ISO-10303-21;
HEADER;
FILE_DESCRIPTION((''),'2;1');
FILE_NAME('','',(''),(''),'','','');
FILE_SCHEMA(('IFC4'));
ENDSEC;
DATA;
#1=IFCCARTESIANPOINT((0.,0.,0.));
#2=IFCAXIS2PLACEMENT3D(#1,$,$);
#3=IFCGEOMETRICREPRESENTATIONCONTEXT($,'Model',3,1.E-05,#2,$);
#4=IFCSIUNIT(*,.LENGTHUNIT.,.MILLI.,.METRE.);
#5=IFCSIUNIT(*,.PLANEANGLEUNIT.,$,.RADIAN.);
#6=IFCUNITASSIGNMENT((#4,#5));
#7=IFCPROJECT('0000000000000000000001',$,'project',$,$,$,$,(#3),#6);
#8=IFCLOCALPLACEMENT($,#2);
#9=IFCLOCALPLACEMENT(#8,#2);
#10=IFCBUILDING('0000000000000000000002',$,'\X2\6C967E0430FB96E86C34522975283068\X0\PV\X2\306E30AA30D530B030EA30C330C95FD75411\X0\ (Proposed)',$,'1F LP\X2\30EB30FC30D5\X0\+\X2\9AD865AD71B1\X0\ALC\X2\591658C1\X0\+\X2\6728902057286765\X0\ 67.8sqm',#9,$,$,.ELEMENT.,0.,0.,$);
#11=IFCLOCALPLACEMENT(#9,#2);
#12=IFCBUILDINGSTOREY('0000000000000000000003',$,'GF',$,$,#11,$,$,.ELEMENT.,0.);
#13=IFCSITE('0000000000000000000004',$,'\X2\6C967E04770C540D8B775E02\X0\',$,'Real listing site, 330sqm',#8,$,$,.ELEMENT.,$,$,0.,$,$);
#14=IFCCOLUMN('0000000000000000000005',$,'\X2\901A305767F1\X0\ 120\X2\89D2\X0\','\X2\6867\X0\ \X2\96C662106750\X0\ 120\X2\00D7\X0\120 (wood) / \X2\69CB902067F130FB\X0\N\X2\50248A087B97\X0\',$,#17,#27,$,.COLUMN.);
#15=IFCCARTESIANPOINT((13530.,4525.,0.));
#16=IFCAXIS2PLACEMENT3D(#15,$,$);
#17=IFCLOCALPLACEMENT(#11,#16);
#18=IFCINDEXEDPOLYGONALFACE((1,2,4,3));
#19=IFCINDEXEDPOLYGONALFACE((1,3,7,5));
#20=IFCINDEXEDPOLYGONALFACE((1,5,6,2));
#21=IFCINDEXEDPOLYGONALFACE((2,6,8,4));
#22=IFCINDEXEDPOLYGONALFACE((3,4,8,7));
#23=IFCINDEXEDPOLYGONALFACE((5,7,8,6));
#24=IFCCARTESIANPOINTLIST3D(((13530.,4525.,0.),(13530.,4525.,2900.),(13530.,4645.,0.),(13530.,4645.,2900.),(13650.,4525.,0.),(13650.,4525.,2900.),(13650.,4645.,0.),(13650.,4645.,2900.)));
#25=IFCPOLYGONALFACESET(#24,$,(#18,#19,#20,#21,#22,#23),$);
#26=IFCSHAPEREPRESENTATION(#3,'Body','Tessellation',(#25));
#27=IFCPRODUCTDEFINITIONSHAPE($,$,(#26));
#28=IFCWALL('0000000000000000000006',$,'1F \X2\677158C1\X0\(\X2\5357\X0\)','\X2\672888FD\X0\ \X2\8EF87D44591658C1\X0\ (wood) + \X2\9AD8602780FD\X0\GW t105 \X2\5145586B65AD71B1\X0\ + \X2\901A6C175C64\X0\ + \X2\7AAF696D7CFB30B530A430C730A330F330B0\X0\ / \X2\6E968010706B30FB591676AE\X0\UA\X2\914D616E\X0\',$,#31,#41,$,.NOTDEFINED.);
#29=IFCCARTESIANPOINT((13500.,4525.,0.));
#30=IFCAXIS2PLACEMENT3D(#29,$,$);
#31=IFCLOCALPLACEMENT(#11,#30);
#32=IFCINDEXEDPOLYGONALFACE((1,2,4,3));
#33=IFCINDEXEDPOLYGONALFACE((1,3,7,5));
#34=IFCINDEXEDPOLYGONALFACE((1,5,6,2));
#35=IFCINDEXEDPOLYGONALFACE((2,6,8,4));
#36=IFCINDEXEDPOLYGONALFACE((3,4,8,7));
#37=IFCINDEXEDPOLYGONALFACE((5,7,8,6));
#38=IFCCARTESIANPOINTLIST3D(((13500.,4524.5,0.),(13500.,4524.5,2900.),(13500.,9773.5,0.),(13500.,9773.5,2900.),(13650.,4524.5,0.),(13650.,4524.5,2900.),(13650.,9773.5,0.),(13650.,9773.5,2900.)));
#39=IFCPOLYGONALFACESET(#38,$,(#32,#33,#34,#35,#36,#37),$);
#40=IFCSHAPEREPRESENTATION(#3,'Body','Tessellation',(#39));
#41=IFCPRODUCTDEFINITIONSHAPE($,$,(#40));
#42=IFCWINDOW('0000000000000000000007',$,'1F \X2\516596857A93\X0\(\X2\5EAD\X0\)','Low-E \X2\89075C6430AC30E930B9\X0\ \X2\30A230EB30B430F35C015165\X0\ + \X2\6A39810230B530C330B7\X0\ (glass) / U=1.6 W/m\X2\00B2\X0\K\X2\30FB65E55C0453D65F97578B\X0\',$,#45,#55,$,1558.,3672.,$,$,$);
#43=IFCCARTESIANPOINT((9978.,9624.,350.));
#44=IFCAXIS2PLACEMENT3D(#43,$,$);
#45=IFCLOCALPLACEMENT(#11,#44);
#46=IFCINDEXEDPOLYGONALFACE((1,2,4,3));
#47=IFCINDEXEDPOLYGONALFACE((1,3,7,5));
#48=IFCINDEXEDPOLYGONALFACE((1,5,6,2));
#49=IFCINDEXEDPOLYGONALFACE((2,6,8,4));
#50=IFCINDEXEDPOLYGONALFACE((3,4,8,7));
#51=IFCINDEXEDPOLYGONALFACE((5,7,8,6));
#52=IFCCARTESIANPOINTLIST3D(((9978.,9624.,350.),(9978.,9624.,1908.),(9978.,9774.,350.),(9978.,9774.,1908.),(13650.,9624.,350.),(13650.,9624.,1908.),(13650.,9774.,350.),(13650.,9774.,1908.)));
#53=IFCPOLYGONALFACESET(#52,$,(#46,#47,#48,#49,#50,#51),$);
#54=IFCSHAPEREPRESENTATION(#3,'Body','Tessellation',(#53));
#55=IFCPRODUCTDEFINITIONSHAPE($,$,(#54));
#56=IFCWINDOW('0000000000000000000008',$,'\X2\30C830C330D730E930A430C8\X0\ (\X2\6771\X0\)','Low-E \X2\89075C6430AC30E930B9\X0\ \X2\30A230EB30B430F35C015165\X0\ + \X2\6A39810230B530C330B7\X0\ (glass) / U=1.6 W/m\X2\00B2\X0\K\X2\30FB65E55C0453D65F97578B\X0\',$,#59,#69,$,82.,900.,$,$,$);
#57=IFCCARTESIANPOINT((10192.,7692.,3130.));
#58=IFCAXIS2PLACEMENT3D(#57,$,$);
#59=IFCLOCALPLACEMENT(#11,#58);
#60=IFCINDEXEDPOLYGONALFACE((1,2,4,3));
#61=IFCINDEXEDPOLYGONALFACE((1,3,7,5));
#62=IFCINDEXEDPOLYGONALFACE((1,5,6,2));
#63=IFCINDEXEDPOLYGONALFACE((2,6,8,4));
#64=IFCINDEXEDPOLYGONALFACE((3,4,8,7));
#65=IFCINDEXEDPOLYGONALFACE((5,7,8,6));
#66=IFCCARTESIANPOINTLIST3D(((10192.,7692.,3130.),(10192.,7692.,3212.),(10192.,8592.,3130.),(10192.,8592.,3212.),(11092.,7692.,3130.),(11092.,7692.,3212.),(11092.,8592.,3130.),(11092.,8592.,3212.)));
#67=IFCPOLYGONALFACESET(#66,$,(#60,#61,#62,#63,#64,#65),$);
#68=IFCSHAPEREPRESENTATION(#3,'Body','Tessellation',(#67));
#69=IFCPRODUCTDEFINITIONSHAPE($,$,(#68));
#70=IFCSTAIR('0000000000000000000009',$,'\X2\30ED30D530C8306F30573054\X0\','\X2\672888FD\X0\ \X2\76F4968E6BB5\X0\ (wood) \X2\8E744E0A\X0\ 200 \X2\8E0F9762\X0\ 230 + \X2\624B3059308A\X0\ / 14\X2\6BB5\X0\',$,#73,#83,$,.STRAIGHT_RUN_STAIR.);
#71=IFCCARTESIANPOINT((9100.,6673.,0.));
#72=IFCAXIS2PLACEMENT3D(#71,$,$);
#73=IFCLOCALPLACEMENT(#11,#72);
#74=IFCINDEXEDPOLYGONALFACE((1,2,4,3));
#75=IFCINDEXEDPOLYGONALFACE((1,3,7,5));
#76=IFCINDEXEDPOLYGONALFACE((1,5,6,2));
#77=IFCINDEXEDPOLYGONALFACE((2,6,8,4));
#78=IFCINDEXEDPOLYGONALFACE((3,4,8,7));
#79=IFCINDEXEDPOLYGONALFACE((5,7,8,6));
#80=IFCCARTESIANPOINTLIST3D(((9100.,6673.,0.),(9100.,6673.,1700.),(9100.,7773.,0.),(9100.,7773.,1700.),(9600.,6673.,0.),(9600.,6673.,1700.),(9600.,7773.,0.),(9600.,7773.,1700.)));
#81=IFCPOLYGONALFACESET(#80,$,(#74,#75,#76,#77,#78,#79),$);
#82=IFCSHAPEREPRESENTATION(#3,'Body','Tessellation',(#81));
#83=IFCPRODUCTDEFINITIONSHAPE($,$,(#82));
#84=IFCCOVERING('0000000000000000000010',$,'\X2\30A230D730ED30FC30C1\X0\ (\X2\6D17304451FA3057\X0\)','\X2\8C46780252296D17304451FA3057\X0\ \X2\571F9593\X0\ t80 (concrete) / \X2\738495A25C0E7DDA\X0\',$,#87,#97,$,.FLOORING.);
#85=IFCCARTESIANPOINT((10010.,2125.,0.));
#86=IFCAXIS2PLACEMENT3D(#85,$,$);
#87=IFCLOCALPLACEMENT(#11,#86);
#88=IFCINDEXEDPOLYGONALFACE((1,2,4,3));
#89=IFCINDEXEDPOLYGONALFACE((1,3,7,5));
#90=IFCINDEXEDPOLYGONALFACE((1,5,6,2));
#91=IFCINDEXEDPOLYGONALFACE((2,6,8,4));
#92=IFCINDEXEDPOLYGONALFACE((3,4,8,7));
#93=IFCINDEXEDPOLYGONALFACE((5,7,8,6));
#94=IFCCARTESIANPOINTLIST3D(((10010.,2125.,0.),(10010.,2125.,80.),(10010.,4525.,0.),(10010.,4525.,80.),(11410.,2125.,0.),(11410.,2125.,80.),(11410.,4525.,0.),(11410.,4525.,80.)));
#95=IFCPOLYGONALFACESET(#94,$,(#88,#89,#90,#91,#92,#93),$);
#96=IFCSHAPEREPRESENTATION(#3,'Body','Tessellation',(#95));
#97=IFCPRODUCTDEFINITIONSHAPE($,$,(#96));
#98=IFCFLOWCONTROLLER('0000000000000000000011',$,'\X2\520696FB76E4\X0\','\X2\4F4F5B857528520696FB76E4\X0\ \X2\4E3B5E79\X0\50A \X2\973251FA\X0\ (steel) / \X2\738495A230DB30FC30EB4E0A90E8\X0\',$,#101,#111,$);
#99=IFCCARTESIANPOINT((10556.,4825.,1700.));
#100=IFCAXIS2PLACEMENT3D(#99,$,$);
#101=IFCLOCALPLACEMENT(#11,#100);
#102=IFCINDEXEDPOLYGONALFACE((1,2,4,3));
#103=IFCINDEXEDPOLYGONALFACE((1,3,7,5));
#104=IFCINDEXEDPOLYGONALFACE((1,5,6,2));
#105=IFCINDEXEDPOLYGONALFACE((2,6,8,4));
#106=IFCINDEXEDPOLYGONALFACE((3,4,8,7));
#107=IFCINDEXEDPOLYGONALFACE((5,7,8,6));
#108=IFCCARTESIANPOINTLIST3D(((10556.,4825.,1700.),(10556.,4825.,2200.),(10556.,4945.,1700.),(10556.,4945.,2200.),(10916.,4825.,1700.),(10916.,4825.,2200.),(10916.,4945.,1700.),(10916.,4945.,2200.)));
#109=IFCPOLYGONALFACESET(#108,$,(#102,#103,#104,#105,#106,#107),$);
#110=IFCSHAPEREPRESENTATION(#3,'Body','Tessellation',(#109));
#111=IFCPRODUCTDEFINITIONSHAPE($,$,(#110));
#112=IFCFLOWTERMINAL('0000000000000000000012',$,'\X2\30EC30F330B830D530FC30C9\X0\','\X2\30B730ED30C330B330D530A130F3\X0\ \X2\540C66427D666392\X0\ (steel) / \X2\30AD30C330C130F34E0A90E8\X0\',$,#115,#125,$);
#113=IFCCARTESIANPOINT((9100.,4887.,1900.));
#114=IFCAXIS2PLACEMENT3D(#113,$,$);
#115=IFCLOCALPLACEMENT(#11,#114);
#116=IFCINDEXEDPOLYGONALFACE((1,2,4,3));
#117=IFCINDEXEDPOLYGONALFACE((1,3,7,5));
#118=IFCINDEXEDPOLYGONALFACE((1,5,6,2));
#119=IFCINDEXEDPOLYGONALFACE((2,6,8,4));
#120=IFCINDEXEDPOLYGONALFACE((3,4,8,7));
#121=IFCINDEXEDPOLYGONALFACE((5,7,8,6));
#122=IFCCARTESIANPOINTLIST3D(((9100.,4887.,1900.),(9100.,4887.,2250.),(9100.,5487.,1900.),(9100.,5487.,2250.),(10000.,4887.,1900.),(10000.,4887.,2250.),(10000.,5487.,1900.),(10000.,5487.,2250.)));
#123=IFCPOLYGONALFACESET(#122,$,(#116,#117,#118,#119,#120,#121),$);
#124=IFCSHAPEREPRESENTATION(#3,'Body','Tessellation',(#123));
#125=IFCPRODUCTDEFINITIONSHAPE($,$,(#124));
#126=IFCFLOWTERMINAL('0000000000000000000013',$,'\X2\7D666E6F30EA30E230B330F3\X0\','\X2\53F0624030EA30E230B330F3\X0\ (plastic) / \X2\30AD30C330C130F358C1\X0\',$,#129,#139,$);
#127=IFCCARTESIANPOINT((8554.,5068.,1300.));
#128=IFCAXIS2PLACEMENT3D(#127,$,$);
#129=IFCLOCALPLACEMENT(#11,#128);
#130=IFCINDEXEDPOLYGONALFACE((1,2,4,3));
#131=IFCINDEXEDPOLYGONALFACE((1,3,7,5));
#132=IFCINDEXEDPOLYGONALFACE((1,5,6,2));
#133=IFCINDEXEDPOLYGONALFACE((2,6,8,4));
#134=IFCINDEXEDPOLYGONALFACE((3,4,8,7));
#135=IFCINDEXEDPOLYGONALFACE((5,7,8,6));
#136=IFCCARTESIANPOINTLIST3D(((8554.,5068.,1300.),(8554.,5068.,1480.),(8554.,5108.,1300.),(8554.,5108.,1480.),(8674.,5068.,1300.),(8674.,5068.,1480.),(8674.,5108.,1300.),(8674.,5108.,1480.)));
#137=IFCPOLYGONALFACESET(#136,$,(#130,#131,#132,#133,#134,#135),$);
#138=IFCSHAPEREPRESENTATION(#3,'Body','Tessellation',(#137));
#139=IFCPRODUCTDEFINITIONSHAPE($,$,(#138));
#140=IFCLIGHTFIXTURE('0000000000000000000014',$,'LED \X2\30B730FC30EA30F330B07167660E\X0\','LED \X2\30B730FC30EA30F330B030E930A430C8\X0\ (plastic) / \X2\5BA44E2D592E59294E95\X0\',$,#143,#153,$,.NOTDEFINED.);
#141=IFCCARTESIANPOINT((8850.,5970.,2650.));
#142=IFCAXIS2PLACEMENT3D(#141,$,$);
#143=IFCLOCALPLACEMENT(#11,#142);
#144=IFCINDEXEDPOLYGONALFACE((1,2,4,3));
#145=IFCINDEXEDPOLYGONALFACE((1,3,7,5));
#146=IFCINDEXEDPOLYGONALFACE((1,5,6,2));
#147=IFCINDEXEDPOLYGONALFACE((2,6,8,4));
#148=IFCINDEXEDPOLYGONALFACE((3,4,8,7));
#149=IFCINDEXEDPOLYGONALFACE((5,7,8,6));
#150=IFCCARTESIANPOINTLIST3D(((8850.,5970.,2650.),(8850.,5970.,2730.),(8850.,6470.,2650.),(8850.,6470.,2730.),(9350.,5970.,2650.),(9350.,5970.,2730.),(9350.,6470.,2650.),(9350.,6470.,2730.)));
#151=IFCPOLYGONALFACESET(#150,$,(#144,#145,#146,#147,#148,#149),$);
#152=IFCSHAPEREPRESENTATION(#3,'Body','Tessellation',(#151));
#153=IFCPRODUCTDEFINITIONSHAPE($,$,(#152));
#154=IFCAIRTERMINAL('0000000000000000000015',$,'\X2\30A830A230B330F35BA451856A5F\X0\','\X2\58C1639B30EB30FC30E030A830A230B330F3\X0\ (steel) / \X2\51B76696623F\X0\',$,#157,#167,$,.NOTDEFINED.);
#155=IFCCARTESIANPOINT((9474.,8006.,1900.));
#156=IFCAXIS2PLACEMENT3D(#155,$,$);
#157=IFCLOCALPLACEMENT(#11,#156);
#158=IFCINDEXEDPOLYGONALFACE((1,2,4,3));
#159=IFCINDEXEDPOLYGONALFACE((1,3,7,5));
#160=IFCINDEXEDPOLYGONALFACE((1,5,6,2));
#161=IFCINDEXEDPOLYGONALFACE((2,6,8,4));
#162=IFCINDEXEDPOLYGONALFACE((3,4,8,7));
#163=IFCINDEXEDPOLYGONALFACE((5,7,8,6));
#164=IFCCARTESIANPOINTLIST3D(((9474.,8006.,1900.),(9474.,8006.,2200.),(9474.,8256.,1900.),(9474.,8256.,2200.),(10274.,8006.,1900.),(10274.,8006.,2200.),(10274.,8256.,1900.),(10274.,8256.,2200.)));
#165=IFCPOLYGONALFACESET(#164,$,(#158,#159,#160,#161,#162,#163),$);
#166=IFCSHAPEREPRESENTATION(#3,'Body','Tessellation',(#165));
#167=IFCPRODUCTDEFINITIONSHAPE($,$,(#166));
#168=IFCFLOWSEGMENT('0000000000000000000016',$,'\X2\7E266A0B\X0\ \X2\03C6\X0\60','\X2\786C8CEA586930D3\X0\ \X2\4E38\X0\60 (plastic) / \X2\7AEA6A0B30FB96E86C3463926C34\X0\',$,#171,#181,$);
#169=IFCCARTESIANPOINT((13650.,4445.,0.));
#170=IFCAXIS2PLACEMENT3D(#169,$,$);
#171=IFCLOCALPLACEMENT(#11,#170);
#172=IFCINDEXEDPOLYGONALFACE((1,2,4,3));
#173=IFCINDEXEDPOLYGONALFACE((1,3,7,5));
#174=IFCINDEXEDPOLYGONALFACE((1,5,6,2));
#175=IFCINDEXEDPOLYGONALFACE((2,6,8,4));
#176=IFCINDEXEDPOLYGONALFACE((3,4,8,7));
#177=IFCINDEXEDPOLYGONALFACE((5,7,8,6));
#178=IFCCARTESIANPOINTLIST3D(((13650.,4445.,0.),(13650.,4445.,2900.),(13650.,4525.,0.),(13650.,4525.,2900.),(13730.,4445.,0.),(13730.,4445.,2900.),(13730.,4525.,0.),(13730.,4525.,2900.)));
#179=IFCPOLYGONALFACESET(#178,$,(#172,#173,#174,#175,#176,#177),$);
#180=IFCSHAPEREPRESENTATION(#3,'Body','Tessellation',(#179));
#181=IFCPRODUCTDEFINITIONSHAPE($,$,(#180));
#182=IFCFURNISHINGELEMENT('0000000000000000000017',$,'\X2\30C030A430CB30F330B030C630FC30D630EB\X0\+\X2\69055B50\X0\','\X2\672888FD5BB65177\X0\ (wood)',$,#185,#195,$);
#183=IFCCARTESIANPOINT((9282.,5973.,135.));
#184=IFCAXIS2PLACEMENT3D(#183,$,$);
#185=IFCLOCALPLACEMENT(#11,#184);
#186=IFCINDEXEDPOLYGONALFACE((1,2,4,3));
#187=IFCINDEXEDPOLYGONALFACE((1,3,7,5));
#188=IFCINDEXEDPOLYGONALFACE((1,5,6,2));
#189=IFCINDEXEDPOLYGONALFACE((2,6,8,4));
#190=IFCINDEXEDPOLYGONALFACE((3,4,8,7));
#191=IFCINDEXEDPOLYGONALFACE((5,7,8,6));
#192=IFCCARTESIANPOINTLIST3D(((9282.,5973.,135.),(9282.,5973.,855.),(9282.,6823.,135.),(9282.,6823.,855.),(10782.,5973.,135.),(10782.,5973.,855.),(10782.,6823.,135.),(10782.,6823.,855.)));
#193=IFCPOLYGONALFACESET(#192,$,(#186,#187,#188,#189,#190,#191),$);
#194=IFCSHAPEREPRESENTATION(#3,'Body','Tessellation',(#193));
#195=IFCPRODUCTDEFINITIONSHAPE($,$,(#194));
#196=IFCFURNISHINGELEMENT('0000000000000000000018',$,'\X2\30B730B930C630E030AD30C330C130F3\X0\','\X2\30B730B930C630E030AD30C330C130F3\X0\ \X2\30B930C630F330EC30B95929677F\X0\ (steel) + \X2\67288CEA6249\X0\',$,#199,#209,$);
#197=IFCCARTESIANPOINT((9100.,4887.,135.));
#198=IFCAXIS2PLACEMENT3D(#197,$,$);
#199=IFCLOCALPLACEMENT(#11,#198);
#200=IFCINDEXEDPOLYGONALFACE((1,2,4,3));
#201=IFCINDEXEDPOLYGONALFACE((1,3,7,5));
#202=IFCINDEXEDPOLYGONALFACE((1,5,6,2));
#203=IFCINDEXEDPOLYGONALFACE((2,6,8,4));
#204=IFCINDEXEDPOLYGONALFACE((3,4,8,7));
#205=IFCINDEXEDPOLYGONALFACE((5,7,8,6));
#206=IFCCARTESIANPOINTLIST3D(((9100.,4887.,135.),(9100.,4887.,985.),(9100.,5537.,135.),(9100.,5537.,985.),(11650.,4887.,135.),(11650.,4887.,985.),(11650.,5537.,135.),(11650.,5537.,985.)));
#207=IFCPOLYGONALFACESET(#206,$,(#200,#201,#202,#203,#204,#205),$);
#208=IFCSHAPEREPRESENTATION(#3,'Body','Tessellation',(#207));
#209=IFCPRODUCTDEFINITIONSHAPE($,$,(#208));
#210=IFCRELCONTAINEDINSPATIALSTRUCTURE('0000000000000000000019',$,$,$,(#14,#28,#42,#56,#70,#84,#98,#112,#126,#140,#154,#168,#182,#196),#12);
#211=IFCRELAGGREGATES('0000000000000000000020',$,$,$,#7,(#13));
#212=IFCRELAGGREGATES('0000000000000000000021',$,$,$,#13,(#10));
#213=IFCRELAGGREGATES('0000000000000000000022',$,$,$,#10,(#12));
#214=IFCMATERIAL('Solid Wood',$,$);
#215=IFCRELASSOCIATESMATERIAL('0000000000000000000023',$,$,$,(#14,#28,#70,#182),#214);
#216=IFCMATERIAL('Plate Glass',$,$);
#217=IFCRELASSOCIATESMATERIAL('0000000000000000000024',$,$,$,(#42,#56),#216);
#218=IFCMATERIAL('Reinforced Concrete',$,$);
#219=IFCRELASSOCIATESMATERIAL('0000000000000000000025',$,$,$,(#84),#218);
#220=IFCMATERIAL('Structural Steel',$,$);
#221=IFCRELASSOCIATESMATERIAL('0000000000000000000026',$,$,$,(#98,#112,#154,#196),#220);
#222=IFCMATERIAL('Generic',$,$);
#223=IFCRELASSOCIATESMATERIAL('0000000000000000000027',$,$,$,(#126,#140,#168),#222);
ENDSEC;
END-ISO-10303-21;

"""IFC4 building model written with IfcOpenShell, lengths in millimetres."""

from ifc_helpers import new_model, si_unit, frame, frame_2d, origin, place, context, project, spatial, rectangle, extrude, material, element, fill, save


model = new_model("IFC4")

# Units and contexts
model_context = context("Model", 3, precision=1e-05, world=origin())
ifc_project = project(units=[si_unit("LENGTHUNIT", "METRE", prefix="MILLI"), si_unit("PLANEANGLEUNIT", "RADIAN")], contexts=[model_context])

# Site, building, storey
site_placement = place(None, origin())
site = spatial("IfcSite", under=ifc_project, at=site_placement, Name="沖縄県名護市", ObjectType="Real listing site, 330sqm", CompositionType="ELEMENT", RefElevation=0.0)
building_placement = place(site_placement, origin())
building = spatial("IfcBuilding", under=site, at=building_placement, Name="沖縄・雨水利用とPVのオフグリッド志向 (Proposed)", ObjectType="1F LPルーフ+高断熱ALC外壁+木造在来 67.8sqm", CompositionType="ELEMENT", ElevationOfRefHeight=0.0, ElevationOfTerrain=0.0)
storey_placement = place(building_placement, origin())
storey = spatial("IfcBuildingStorey", under=building, at=storey_placement, Name="GF", CompositionType="ELEMENT", Elevation=0.0)

# Column
ifc_material_1 = material(Name="Solid Wood")
column_1_placement = place(storey_placement, frame((13530.0, 4525.0, 0.0)))
element("IfcColumn", 1, at=column_1_placement, inside=storey, material=ifc_material_1, Name="通し柱 120角", Description="桧 集成材 120×120 (wood) / 構造柱・N値計算", PredefinedType="COLUMN", context=model_context, shape_type="SweptSolid", body=[
    extrude(rectangle(XDim=120.0, YDim=120.0, at=frame_2d((60.0, 60.0))), frame((13530.0, 4525.0, 0.0)), (0.0, 0.0, 1.0), 2900.0),
])

# Wall, opening, window
wall_1_placement = place(storey_placement, frame((13500.0, 4525.0, 0.0)))
wall_1 = element("IfcWall", 2, at=wall_1_placement, inside=storey, material=ifc_material_1, Name="1F 東壁(南)", Description="木製 軸組外壁 (wood) + 高性能GW t105 充填断熱 + 通気層 + 窯業系サイディング / 準耐火・外皮UA配慮", PredefinedType="NOTDEFINED", context=model_context, shape_type="SweptSolid", body=[
    extrude(rectangle(XDim=150.0, YDim=5249.0, at=frame_2d((75.0, 2624.0))), frame((13500.0, 4525.0, 0.0)), (0.0, 0.0, 1.0), 2900.0),
])
opening_1_placement = place(storey_placement, frame((9978.0, 9624.0, 350.0)))
opening_1 = element("IfcOpeningElement", 3, at=opening_1_placement, cuts=wall_1, PredefinedType="NOTDEFINED", context=model_context, shape_type="SweptSolid", body=[
    extrude(rectangle(XDim=3672.0, YDim=150.0, at=frame_2d((1836.0, 75.0))), frame((9978.0, 9624.0, 350.0)), (0.0, 0.0, 1.0), 1558.0),
])
ifc_material_2 = material(Name="Plate Glass")
window_1_placement = place(storey_placement, frame((9978.0, 9624.0, 350.0)))
window_1 = element("IfcWindow", 4, at=window_1_placement, inside=storey, material=ifc_material_2, Name="1F 入隅窓(庭)", Description="Low-E 複層ガラス アルゴン封入 + 樹脂サッシ (glass) / U=1.6 W/m²K・日射取得型", OverallHeight=1558.0, OverallWidth=3672.0, context=model_context, shape_type="SweptSolid", body=[
    extrude(rectangle(XDim=3672.0, YDim=150.0, at=frame_2d((1836.0, 75.0))), frame((9978.0, 9624.0, 350.0)), (0.0, 0.0, 1.0), 1558.0),
])
fill(opening_1, window_1)

# Window
window_2_placement = place(storey_placement, frame((10192.0, 7692.0, 3130.0)))
element("IfcWindow", 5, at=window_2_placement, inside=storey, material=ifc_material_2, Name="トップライト (東)", Description="Low-E 複層ガラス アルゴン封入 + 樹脂サッシ (glass) / U=1.6 W/m²K・日射取得型", OverallHeight=82.0, OverallWidth=900.0, context=model_context, shape_type="SweptSolid", body=[
    extrude(rectangle(XDim=900.0, YDim=900.0, at=frame_2d((450.0, 450.0))), frame((10192.0, 7692.0, 3130.0)), (0.0, 0.0, 1.0), 82.0),
])

# Stair
stair_placement = place(storey_placement, frame((9100.0, 6673.0, 0.0)))
element("IfcStair", 6, at=stair_placement, inside=storey, material=ifc_material_1, Name="ロフトはしご", Description="木製 直階段 (wood) 蹴上 200 踏面 230 + 手すり / 14段", PredefinedType="STRAIGHT_RUN_STAIR", context=model_context, shape_type="SweptSolid", body=[
    extrude(rectangle(XDim=500.0, YDim=1100.0, at=frame_2d((250.0, 550.0))), frame((9100.0, 6673.0, 0.0)), (0.0, 0.0, 1.0), 1700.0),
])

# Covering
ifc_material_3 = material(Name="Reinforced Concrete")
covering_placement = place(storey_placement, frame((10010.0, 2125.0, 0.0)))
element("IfcCovering", 7, at=covering_placement, inside=storey, material=ifc_material_3, Name="アプローチ (洗い出し)", Description="豆砂利洗い出し 土間 t80 (concrete) / 玄関導線", PredefinedType="FLOORING", context=model_context, shape_type="SweptSolid", body=[
    extrude(rectangle(XDim=1400.0, YDim=2400.0, at=frame_2d((700.0, 1200.0))), frame((10010.0, 2125.0, 0.0)), (0.0, 0.0, 1.0), 80.0),
])

# Flow controller
ifc_material_4 = material(Name="Structural Steel")
flow_controller_placement = place(storey_placement, frame((10556.0, 4825.0, 1700.0)))
element("IfcFlowController", 8, at=flow_controller_placement, inside=storey, material=ifc_material_4, Name="分電盤", Description="住宅用分電盤 主幹50A 露出 (steel) / 玄関ホール上部", context=model_context, shape_type="SweptSolid", body=[
    extrude(rectangle(XDim=360.0, YDim=120.0, at=frame_2d((180.0, 60.0))), frame((10556.0, 4825.0, 1700.0)), (0.0, 0.0, 1.0), 500.0),
])

# Flow terminals
flow_terminal_1_placement = place(storey_placement, frame((9100.0, 4887.0, 1900.0)))
element("IfcFlowTerminal", 9, at=flow_terminal_1_placement, inside=storey, material=ifc_material_4, Name="レンジフード", Description="シロッコファン 同時給排 (steel) / キッチン上部", context=model_context, shape_type="SweptSolid", body=[
    extrude(rectangle(XDim=900.0, YDim=600.0, at=frame_2d((450.0, 300.0))), frame((9100.0, 4887.0, 1900.0)), (0.0, 0.0, 1.0), 350.0),
])
ifc_material_5 = material(Name="Generic")
flow_terminal_2_placement = place(storey_placement, frame((8554.0, 5068.0, 1300.0)))
element("IfcFlowTerminal", 10, at=flow_terminal_2_placement, inside=storey, material=ifc_material_5, Name="給湯リモコン", Description="台所リモコン (plastic) / キッチン壁", context=model_context, shape_type="SweptSolid", body=[
    extrude(rectangle(XDim=120.0, YDim=40.0, at=frame_2d((60.0, 20.0))), frame((8554.0, 5068.0, 1300.0)), (0.0, 0.0, 1.0), 180.0),
])

# Light fixture
light_fixture_placement = place(storey_placement, frame((8850.0, 5970.0, 2650.0)))
element("IfcLightFixture", 11, at=light_fixture_placement, inside=storey, material=ifc_material_5, Name="LED シーリング照明", Description="LED シーリングライト (plastic) / 室中央天井", PredefinedType="NOTDEFINED", context=model_context, shape_type="SweptSolid", body=[
    extrude(rectangle(XDim=500.0, YDim=500.0, at=frame_2d((250.0, 250.0))), frame((8850.0, 5970.0, 2650.0)), (0.0, 0.0, 1.0), 80.0),
])

# Air terminal
air_terminal_placement = place(storey_placement, frame((9474.0, 8006.0, 1900.0)))
element("IfcAirTerminal", 12, at=air_terminal_placement, inside=storey, material=ifc_material_4, Name="エアコン室内機", Description="壁掛ルームエアコン (steel) / 冷暖房", PredefinedType="NOTDEFINED", context=model_context, shape_type="SweptSolid", body=[
    extrude(rectangle(XDim=800.0, YDim=250.0, at=frame_2d((400.0, 125.0))), frame((9474.0, 8006.0, 1900.0)), (0.0, 0.0, 1.0), 300.0),
])

# Flow segment
flow_segment_placement = place(storey_placement, frame((13650.0, 4445.0, 0.0)))
element("IfcFlowSegment", 13, at=flow_segment_placement, inside=storey, material=ifc_material_5, Name="縦樋 φ60", Description="硬質塩ビ 丸60 (plastic) / 竪樋・雨水排水", context=model_context, shape_type="SweptSolid", body=[
    extrude(rectangle(XDim=80.0, YDim=80.0, at=frame_2d((40.0, 40.0))), frame((13650.0, 4445.0, 0.0)), (0.0, 0.0, 1.0), 2900.0),
])

# Furnishing elements
furnishing_1_placement = place(storey_placement, frame((9282.0, 5973.0, 135.0)))
element("IfcFurnishingElement", 14, at=furnishing_1_placement, inside=storey, material=ifc_material_1, Name="ダイニングテーブル+椅子", Description="木製家具 (wood)", context=model_context, shape_type="SweptSolid", body=[
    extrude(rectangle(XDim=1500.0, YDim=850.0, at=frame_2d((750.0, 425.0))), frame((9282.0, 5973.0, 135.0)), (0.0, 0.0, 1.0), 720.0),
])
furnishing_2_placement = place(storey_placement, frame((9100.0, 4887.0, 135.0)))
element("IfcFurnishingElement", 15, at=furnishing_2_placement, inside=storey, material=ifc_material_4, Name="システムキッチン", Description="システムキッチン ステンレス天板 (steel) + 木質扉", context=model_context, shape_type="SweptSolid", body=[
    extrude(rectangle(XDim=2550.0, YDim=650.0, at=frame_2d((1275.0, 325.0))), frame((9100.0, 4887.0, 135.0)), (0.0, 0.0, 1.0), 850.0),
])

save(model, "model.ifc")
